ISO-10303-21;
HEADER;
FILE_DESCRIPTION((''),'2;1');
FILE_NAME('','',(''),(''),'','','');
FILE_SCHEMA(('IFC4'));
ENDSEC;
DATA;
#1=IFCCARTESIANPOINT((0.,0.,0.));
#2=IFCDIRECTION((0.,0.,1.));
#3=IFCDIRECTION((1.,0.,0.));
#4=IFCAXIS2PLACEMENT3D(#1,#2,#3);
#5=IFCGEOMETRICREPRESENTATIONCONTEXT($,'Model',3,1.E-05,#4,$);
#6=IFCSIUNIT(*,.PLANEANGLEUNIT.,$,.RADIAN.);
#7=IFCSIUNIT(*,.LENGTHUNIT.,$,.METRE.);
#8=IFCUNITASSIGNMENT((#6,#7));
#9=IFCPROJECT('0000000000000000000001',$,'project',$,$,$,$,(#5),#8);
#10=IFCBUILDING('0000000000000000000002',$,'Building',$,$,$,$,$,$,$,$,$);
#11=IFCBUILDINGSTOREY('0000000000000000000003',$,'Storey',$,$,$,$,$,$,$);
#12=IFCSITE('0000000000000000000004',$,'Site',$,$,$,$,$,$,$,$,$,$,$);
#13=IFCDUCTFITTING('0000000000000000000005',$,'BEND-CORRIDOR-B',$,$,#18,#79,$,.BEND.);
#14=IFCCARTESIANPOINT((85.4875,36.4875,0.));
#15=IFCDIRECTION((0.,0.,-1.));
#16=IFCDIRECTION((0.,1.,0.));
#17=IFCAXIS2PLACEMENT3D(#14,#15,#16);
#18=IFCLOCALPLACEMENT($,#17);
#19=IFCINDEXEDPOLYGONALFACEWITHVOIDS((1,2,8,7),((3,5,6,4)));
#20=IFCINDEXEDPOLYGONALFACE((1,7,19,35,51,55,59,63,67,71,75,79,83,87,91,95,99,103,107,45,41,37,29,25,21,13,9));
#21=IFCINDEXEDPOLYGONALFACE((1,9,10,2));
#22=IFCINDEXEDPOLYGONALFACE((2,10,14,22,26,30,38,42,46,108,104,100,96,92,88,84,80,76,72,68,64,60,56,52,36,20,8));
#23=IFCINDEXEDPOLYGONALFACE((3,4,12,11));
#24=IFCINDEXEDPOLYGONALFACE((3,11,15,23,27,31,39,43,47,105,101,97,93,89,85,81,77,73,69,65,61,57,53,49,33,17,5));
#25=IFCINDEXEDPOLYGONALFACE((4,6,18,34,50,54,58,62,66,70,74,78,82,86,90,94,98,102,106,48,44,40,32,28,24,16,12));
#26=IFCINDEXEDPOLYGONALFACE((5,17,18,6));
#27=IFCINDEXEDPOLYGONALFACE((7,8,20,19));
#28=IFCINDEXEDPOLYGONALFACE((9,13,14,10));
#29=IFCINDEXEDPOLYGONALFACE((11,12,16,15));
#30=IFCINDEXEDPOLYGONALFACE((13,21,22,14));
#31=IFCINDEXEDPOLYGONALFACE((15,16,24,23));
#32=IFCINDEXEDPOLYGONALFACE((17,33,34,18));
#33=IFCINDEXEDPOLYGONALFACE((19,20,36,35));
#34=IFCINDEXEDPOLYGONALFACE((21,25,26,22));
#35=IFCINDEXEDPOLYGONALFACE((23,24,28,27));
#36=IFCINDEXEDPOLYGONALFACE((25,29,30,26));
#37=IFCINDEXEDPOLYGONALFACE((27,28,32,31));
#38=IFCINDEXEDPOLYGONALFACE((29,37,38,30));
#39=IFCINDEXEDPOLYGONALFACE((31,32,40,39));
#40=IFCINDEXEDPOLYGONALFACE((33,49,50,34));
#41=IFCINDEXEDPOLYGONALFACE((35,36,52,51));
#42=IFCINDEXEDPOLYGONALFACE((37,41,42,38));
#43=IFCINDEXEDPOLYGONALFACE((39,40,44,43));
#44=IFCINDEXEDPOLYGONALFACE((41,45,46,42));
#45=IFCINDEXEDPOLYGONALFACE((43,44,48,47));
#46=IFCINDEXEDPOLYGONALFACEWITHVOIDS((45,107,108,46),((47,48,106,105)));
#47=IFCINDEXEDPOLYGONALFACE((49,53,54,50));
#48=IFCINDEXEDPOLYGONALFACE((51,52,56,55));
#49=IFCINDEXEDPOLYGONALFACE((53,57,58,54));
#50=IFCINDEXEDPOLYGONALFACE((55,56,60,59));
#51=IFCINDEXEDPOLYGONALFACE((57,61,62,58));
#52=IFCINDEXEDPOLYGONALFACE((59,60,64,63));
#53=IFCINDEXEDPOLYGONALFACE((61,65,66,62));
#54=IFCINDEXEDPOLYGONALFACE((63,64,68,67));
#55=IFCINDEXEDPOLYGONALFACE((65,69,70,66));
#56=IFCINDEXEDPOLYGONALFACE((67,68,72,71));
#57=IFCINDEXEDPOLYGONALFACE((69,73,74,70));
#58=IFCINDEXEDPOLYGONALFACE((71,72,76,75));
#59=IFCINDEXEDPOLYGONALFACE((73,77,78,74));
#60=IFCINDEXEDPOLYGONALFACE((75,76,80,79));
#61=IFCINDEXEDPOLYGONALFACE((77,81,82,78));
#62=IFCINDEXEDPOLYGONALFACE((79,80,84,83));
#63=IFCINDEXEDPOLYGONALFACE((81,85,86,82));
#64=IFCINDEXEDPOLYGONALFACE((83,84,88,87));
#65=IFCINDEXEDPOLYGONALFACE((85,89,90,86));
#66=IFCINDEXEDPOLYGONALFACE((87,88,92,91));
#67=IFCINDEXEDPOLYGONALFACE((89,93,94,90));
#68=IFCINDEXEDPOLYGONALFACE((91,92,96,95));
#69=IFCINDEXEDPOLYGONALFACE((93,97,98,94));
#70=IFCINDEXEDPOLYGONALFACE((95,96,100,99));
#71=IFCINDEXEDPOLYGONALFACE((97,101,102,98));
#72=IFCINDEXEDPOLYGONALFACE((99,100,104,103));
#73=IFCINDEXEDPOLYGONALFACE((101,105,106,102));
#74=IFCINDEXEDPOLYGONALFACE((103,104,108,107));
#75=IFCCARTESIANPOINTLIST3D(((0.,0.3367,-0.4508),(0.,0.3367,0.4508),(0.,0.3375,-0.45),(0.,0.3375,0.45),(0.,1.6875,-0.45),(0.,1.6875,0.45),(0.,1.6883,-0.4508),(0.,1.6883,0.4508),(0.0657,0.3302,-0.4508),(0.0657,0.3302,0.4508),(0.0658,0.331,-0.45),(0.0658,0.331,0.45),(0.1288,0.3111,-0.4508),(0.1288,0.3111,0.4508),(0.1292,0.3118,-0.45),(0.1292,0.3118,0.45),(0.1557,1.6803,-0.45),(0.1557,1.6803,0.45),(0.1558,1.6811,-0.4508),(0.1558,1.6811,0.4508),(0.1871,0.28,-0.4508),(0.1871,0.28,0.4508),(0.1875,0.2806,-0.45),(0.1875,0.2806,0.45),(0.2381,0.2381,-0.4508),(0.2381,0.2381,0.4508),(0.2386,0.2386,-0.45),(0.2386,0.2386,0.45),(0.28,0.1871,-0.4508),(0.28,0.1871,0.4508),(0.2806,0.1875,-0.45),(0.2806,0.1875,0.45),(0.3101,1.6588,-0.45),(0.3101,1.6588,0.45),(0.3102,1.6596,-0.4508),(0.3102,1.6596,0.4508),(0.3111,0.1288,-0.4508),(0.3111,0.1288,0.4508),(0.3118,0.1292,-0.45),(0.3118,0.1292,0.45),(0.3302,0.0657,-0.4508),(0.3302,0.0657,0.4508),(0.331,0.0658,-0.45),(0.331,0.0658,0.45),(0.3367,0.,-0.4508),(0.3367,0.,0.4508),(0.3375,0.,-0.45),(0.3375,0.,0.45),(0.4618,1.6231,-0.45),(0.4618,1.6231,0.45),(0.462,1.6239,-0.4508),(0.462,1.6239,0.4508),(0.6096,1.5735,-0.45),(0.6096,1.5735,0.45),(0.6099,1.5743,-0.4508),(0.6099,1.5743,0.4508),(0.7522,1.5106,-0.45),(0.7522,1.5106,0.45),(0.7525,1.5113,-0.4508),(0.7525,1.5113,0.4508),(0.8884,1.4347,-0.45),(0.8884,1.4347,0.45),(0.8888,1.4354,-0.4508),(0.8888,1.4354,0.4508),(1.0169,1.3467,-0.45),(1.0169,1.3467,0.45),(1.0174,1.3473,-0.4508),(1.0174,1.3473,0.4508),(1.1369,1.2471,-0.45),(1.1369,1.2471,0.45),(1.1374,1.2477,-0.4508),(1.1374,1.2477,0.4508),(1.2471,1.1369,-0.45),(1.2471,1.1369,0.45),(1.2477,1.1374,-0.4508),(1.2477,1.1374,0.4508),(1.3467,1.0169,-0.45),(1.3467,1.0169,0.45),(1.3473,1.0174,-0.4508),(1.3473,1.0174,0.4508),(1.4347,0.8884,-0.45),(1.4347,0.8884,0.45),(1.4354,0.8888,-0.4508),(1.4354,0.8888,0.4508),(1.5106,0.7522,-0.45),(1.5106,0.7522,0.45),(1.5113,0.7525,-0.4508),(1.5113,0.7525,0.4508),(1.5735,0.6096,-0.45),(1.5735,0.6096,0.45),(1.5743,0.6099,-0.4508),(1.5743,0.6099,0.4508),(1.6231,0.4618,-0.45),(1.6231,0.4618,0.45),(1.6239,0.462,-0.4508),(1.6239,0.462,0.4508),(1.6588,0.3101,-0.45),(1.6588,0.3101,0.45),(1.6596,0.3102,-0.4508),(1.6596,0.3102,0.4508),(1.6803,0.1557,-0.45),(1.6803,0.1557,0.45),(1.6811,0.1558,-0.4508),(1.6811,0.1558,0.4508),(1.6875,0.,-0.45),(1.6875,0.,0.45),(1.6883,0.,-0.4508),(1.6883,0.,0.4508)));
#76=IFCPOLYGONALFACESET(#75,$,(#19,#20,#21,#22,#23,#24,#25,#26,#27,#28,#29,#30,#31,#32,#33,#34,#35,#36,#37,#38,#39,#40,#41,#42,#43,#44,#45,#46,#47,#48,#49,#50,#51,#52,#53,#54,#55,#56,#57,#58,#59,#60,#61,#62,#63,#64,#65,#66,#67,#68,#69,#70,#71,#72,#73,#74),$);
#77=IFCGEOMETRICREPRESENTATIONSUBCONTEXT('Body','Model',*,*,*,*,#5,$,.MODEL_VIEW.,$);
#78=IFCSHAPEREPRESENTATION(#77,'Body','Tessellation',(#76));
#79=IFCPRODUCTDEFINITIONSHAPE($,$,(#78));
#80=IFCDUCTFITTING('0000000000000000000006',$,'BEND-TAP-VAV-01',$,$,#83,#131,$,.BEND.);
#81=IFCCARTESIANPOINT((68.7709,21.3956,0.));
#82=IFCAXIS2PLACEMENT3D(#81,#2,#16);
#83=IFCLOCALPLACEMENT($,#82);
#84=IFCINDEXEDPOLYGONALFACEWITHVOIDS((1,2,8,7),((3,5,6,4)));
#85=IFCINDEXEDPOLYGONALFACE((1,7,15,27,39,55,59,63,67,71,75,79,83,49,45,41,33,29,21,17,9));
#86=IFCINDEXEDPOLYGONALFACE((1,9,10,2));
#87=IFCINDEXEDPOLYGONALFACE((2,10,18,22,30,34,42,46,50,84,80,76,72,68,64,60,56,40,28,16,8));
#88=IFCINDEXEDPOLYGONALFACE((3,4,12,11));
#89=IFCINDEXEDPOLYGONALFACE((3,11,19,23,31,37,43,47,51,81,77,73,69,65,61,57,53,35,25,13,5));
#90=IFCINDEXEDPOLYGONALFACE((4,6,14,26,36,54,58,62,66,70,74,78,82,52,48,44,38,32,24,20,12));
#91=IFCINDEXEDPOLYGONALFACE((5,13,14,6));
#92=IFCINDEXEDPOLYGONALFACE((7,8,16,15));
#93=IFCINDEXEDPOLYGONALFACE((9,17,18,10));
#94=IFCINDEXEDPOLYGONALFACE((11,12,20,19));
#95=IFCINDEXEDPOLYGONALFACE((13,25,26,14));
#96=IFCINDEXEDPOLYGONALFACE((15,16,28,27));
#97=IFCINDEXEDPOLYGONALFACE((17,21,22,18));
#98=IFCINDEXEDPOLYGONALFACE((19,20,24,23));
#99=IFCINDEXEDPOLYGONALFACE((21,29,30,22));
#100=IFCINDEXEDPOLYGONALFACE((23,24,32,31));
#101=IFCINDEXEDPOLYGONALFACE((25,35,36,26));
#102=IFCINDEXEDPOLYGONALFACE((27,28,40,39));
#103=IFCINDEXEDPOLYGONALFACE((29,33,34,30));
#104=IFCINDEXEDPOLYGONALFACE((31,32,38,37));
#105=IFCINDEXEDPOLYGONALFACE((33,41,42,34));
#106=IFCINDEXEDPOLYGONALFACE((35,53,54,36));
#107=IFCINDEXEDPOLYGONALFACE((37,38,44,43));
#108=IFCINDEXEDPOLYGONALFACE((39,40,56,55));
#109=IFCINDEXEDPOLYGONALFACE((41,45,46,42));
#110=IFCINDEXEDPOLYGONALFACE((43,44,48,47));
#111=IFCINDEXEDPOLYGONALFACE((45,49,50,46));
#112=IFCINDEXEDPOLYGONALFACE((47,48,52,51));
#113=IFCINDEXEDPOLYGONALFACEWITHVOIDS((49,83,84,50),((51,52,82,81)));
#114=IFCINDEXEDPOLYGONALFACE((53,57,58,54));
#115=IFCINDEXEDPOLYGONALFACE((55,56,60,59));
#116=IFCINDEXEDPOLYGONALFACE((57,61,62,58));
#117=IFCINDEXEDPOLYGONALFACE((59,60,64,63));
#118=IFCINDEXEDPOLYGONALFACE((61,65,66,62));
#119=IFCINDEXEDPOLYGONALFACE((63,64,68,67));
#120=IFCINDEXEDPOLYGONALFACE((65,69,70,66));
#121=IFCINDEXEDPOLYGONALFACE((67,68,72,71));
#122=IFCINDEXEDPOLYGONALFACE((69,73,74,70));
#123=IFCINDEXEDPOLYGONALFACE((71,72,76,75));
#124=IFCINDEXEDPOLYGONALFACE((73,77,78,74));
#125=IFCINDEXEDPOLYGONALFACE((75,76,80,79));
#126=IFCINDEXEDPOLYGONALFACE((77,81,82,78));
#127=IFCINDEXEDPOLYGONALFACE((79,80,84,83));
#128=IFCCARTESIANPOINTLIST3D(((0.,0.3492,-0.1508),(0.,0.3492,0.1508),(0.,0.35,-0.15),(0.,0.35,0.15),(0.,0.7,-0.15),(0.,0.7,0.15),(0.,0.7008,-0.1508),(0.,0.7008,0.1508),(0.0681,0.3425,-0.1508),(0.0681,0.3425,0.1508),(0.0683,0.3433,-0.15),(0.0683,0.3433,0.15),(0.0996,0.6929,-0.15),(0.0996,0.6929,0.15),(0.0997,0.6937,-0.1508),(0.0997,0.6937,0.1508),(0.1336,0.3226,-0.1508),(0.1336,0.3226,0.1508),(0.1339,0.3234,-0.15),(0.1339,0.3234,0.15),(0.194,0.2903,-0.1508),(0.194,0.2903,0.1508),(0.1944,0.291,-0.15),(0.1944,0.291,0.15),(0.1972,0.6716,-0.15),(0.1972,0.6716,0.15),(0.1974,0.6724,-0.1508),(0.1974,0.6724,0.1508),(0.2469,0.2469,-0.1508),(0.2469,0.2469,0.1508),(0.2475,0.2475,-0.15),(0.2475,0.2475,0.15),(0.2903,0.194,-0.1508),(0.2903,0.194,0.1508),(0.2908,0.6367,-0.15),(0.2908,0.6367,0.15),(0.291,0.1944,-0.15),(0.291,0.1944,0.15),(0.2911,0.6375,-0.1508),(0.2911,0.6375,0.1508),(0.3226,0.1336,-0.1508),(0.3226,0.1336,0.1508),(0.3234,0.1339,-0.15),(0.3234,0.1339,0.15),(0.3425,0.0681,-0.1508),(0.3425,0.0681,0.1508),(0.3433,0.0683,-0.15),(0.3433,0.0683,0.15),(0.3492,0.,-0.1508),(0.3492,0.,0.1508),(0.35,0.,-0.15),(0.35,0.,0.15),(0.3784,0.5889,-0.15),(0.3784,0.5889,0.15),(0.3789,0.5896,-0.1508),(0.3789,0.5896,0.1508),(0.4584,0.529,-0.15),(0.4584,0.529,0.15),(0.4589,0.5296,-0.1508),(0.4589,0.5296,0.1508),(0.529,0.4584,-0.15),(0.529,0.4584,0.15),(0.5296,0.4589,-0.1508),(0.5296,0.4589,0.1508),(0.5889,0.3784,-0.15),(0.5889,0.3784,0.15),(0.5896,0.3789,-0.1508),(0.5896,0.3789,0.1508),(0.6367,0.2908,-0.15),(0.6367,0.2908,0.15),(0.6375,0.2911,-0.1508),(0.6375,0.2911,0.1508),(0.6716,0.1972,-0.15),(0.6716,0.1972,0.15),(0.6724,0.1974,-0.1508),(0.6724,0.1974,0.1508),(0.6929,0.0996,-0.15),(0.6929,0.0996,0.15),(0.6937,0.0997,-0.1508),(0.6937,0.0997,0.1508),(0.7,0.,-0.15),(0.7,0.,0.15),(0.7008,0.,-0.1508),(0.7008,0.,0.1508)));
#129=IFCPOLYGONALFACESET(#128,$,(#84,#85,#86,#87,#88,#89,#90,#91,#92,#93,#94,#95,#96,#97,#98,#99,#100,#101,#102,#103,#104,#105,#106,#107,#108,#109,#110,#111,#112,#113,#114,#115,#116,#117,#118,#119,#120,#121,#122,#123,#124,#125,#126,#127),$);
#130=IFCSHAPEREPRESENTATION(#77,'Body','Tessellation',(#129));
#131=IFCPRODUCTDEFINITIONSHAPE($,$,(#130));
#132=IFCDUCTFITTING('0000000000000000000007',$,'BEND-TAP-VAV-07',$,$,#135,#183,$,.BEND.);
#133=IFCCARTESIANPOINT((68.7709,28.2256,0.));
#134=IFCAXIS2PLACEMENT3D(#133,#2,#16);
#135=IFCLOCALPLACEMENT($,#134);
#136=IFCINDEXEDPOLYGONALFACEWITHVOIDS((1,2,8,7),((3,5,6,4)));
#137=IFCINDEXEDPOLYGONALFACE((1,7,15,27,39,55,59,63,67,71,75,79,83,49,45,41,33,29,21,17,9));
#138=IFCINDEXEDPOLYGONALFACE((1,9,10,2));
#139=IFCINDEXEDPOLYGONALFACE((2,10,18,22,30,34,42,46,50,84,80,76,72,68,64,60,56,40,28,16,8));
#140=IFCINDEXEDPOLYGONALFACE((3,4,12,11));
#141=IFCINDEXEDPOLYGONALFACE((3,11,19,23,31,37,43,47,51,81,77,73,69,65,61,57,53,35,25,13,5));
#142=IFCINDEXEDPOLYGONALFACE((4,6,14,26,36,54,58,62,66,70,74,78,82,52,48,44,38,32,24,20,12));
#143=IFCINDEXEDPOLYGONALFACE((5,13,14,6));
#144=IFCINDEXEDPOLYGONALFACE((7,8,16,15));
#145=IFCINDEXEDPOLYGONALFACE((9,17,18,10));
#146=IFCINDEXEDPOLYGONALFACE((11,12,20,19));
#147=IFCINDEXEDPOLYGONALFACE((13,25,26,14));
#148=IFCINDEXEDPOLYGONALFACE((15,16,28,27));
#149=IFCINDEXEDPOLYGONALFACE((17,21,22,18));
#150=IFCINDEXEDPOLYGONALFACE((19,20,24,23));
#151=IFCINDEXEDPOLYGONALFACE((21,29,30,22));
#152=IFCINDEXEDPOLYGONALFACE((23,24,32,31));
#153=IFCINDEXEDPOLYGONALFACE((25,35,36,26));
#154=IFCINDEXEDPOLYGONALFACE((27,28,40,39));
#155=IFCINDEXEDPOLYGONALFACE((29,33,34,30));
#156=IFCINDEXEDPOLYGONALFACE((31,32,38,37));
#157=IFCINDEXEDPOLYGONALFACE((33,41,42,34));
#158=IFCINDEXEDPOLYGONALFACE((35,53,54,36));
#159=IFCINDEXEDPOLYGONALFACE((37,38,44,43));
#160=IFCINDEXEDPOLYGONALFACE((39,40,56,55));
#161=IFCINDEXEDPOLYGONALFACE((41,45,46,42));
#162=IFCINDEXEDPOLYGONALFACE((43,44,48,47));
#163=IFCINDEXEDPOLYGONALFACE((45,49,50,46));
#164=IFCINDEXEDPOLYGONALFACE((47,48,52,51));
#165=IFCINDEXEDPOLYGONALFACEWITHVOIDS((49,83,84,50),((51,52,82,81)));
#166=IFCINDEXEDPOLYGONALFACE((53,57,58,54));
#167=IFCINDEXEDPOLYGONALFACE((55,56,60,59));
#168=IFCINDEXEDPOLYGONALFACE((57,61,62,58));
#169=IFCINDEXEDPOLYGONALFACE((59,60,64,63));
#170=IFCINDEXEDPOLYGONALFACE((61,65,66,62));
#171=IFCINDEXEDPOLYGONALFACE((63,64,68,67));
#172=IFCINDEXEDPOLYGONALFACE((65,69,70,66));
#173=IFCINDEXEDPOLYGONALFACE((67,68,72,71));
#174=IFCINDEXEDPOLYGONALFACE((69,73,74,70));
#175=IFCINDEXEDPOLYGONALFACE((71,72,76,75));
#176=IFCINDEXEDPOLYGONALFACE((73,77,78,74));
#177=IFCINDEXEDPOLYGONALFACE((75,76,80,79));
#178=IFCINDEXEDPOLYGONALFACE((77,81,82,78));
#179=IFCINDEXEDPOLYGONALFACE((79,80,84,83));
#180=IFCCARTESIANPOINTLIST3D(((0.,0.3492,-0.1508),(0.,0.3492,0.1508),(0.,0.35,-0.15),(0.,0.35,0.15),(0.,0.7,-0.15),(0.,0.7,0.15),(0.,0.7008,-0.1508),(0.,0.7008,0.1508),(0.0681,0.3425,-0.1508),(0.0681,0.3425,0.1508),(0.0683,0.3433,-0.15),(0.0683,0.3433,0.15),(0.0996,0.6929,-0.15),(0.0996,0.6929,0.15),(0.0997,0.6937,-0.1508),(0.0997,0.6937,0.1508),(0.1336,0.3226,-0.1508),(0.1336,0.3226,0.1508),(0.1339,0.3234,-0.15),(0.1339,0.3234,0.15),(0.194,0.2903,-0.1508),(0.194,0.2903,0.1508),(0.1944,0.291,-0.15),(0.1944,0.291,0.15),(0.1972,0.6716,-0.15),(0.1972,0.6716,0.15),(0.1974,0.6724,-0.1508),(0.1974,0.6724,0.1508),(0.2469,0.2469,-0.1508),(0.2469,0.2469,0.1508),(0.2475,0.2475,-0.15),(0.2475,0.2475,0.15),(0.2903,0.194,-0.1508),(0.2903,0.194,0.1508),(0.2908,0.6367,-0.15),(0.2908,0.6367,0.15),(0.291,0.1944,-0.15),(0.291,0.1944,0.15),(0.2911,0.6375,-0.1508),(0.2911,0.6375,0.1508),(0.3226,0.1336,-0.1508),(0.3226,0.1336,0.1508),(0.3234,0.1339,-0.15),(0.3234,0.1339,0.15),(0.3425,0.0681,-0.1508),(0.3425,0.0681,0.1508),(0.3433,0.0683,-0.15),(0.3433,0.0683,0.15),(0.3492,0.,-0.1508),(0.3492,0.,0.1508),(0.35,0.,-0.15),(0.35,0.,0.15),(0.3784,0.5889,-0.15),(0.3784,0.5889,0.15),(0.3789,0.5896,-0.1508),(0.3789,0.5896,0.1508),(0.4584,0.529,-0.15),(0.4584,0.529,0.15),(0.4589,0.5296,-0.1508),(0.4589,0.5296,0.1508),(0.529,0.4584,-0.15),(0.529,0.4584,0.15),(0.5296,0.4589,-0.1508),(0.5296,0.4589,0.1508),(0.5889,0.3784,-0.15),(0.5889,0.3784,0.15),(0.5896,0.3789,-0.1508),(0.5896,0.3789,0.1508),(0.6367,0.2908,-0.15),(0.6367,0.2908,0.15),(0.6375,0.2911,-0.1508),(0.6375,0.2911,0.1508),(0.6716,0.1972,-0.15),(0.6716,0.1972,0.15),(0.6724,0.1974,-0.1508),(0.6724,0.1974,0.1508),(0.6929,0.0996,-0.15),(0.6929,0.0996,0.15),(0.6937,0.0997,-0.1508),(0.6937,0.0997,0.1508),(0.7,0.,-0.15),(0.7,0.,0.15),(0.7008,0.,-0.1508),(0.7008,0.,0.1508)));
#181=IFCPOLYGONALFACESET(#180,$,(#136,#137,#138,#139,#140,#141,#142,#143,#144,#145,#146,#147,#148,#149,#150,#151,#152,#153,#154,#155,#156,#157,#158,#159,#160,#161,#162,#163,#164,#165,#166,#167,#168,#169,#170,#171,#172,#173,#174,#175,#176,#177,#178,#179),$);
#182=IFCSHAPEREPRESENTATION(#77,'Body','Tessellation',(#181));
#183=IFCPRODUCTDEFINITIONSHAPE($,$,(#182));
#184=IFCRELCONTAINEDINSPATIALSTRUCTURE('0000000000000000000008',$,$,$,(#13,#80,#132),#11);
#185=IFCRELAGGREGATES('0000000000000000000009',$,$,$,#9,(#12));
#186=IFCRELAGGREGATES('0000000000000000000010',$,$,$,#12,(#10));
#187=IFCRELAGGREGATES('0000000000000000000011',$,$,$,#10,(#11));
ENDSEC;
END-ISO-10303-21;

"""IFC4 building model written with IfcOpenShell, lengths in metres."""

from ifc_helpers import new_model, entity, si_unit, frame, origin_with_axes, place, context, subcontext, project, spatial, element, save


model = new_model("IFC4")

# Units and contexts
model_context = context("Model", 3, precision=1e-05, world=origin_with_axes())
body_context = subcontext(model_context, "Body", "Model", "MODEL_VIEW")
ifc_project = project(units=[si_unit("PLANEANGLEUNIT", "RADIAN"), si_unit("LENGTHUNIT", "METRE")], contexts=[model_context])

# Site, building, storey
site = spatial("IfcSite", under=ifc_project, Name="Site")
building = spatial("IfcBuilding", under=site, Name="Building")
storey = spatial("IfcBuildingStorey", under=building, Name="Storey")

# Duct fittings
duct_fitting_1_placement = place(None, frame((85.4875, 36.4875, 0.0), z_axis=(0.0, 0.0, -1.0), x_axis=(0.0, 1.0, 0.0)))
cartesian_point_1 = entity("IfcCartesianPoint", [0.0, 0.0, 0.0])
element("IfcDuctFitting", 1, at=duct_fitting_1_placement, inside=storey, Name="BEND-CORRIDOR-B", PredefinedType="BEND", context=body_context, shape_type="SweptSolid", body=[
    entity("IfcRevolvedAreaSolid", entity("IfcRectangleHollowProfileDef", "AREA", None, entity("IfcAxis2Placement2D", entity("IfcCartesianPoint", [1.0125, 0.0])), 1.3516, 0.9016, 0.0008), entity("IfcAxis2Placement3D", cartesian_point_1, entity("IfcDirection", [0.0, -1.0, 0.0]), entity("IfcDirection", [1.0, 0.0, 0.0])), entity("IfcAxis1Placement", cartesian_point_1, entity("IfcDirection", [0.0, 1.0, 0.0])), 1.570796),
])
duct_fitting_2_placement = place(None, frame((68.7709, 21.3956, 0.0), z_axis=(0.0, 0.0, 1.0), x_axis=(0.0, 1.0, 0.0)))
cartesian_point_2 = entity("IfcCartesianPoint", [0.0, 0.0, 0.0])
element("IfcDuctFitting", 2, at=duct_fitting_2_placement, inside=storey, Name="BEND-TAP-VAV-01", PredefinedType="BEND", context=body_context, shape_type="SweptSolid", body=[
    entity("IfcRevolvedAreaSolid", entity("IfcRectangleHollowProfileDef", "AREA", None, entity("IfcAxis2Placement2D", entity("IfcCartesianPoint", [0.525, 0.0])), 0.3516, 0.3016, 0.0008), entity("IfcAxis2Placement3D", cartesian_point_2, entity("IfcDirection", [0.0, -1.0, 0.0]), entity("IfcDirection", [1.0, 0.0, 0.0])), entity("IfcAxis1Placement", cartesian_point_2, entity("IfcDirection", [0.0, 1.0, 0.0])), 1.570796),
])
duct_fitting_3_placement = place(None, frame((68.7709, 28.2256, 0.0), z_axis=(0.0, 0.0, 1.0), x_axis=(0.0, 1.0, 0.0)))
cartesian_point_3 = entity("IfcCartesianPoint", [0.0, 0.0, 0.0])
element("IfcDuctFitting", 3, at=duct_fitting_3_placement, inside=storey, Name="BEND-TAP-VAV-07", PredefinedType="BEND", context=body_context, shape_type="SweptSolid", body=[
    entity("IfcRevolvedAreaSolid", entity("IfcRectangleHollowProfileDef", "AREA", None, entity("IfcAxis2Placement2D", entity("IfcCartesianPoint", [0.525, 0.0])), 0.3516, 0.3016, 0.0008), entity("IfcAxis2Placement3D", cartesian_point_3, entity("IfcDirection", [0.0, -1.0, 0.0]), entity("IfcDirection", [1.0, 0.0, 0.0])), entity("IfcAxis1Placement", cartesian_point_3, entity("IfcDirection", [0.0, 1.0, 0.0])), 1.570796),
])

save(model, "model.ifc")
